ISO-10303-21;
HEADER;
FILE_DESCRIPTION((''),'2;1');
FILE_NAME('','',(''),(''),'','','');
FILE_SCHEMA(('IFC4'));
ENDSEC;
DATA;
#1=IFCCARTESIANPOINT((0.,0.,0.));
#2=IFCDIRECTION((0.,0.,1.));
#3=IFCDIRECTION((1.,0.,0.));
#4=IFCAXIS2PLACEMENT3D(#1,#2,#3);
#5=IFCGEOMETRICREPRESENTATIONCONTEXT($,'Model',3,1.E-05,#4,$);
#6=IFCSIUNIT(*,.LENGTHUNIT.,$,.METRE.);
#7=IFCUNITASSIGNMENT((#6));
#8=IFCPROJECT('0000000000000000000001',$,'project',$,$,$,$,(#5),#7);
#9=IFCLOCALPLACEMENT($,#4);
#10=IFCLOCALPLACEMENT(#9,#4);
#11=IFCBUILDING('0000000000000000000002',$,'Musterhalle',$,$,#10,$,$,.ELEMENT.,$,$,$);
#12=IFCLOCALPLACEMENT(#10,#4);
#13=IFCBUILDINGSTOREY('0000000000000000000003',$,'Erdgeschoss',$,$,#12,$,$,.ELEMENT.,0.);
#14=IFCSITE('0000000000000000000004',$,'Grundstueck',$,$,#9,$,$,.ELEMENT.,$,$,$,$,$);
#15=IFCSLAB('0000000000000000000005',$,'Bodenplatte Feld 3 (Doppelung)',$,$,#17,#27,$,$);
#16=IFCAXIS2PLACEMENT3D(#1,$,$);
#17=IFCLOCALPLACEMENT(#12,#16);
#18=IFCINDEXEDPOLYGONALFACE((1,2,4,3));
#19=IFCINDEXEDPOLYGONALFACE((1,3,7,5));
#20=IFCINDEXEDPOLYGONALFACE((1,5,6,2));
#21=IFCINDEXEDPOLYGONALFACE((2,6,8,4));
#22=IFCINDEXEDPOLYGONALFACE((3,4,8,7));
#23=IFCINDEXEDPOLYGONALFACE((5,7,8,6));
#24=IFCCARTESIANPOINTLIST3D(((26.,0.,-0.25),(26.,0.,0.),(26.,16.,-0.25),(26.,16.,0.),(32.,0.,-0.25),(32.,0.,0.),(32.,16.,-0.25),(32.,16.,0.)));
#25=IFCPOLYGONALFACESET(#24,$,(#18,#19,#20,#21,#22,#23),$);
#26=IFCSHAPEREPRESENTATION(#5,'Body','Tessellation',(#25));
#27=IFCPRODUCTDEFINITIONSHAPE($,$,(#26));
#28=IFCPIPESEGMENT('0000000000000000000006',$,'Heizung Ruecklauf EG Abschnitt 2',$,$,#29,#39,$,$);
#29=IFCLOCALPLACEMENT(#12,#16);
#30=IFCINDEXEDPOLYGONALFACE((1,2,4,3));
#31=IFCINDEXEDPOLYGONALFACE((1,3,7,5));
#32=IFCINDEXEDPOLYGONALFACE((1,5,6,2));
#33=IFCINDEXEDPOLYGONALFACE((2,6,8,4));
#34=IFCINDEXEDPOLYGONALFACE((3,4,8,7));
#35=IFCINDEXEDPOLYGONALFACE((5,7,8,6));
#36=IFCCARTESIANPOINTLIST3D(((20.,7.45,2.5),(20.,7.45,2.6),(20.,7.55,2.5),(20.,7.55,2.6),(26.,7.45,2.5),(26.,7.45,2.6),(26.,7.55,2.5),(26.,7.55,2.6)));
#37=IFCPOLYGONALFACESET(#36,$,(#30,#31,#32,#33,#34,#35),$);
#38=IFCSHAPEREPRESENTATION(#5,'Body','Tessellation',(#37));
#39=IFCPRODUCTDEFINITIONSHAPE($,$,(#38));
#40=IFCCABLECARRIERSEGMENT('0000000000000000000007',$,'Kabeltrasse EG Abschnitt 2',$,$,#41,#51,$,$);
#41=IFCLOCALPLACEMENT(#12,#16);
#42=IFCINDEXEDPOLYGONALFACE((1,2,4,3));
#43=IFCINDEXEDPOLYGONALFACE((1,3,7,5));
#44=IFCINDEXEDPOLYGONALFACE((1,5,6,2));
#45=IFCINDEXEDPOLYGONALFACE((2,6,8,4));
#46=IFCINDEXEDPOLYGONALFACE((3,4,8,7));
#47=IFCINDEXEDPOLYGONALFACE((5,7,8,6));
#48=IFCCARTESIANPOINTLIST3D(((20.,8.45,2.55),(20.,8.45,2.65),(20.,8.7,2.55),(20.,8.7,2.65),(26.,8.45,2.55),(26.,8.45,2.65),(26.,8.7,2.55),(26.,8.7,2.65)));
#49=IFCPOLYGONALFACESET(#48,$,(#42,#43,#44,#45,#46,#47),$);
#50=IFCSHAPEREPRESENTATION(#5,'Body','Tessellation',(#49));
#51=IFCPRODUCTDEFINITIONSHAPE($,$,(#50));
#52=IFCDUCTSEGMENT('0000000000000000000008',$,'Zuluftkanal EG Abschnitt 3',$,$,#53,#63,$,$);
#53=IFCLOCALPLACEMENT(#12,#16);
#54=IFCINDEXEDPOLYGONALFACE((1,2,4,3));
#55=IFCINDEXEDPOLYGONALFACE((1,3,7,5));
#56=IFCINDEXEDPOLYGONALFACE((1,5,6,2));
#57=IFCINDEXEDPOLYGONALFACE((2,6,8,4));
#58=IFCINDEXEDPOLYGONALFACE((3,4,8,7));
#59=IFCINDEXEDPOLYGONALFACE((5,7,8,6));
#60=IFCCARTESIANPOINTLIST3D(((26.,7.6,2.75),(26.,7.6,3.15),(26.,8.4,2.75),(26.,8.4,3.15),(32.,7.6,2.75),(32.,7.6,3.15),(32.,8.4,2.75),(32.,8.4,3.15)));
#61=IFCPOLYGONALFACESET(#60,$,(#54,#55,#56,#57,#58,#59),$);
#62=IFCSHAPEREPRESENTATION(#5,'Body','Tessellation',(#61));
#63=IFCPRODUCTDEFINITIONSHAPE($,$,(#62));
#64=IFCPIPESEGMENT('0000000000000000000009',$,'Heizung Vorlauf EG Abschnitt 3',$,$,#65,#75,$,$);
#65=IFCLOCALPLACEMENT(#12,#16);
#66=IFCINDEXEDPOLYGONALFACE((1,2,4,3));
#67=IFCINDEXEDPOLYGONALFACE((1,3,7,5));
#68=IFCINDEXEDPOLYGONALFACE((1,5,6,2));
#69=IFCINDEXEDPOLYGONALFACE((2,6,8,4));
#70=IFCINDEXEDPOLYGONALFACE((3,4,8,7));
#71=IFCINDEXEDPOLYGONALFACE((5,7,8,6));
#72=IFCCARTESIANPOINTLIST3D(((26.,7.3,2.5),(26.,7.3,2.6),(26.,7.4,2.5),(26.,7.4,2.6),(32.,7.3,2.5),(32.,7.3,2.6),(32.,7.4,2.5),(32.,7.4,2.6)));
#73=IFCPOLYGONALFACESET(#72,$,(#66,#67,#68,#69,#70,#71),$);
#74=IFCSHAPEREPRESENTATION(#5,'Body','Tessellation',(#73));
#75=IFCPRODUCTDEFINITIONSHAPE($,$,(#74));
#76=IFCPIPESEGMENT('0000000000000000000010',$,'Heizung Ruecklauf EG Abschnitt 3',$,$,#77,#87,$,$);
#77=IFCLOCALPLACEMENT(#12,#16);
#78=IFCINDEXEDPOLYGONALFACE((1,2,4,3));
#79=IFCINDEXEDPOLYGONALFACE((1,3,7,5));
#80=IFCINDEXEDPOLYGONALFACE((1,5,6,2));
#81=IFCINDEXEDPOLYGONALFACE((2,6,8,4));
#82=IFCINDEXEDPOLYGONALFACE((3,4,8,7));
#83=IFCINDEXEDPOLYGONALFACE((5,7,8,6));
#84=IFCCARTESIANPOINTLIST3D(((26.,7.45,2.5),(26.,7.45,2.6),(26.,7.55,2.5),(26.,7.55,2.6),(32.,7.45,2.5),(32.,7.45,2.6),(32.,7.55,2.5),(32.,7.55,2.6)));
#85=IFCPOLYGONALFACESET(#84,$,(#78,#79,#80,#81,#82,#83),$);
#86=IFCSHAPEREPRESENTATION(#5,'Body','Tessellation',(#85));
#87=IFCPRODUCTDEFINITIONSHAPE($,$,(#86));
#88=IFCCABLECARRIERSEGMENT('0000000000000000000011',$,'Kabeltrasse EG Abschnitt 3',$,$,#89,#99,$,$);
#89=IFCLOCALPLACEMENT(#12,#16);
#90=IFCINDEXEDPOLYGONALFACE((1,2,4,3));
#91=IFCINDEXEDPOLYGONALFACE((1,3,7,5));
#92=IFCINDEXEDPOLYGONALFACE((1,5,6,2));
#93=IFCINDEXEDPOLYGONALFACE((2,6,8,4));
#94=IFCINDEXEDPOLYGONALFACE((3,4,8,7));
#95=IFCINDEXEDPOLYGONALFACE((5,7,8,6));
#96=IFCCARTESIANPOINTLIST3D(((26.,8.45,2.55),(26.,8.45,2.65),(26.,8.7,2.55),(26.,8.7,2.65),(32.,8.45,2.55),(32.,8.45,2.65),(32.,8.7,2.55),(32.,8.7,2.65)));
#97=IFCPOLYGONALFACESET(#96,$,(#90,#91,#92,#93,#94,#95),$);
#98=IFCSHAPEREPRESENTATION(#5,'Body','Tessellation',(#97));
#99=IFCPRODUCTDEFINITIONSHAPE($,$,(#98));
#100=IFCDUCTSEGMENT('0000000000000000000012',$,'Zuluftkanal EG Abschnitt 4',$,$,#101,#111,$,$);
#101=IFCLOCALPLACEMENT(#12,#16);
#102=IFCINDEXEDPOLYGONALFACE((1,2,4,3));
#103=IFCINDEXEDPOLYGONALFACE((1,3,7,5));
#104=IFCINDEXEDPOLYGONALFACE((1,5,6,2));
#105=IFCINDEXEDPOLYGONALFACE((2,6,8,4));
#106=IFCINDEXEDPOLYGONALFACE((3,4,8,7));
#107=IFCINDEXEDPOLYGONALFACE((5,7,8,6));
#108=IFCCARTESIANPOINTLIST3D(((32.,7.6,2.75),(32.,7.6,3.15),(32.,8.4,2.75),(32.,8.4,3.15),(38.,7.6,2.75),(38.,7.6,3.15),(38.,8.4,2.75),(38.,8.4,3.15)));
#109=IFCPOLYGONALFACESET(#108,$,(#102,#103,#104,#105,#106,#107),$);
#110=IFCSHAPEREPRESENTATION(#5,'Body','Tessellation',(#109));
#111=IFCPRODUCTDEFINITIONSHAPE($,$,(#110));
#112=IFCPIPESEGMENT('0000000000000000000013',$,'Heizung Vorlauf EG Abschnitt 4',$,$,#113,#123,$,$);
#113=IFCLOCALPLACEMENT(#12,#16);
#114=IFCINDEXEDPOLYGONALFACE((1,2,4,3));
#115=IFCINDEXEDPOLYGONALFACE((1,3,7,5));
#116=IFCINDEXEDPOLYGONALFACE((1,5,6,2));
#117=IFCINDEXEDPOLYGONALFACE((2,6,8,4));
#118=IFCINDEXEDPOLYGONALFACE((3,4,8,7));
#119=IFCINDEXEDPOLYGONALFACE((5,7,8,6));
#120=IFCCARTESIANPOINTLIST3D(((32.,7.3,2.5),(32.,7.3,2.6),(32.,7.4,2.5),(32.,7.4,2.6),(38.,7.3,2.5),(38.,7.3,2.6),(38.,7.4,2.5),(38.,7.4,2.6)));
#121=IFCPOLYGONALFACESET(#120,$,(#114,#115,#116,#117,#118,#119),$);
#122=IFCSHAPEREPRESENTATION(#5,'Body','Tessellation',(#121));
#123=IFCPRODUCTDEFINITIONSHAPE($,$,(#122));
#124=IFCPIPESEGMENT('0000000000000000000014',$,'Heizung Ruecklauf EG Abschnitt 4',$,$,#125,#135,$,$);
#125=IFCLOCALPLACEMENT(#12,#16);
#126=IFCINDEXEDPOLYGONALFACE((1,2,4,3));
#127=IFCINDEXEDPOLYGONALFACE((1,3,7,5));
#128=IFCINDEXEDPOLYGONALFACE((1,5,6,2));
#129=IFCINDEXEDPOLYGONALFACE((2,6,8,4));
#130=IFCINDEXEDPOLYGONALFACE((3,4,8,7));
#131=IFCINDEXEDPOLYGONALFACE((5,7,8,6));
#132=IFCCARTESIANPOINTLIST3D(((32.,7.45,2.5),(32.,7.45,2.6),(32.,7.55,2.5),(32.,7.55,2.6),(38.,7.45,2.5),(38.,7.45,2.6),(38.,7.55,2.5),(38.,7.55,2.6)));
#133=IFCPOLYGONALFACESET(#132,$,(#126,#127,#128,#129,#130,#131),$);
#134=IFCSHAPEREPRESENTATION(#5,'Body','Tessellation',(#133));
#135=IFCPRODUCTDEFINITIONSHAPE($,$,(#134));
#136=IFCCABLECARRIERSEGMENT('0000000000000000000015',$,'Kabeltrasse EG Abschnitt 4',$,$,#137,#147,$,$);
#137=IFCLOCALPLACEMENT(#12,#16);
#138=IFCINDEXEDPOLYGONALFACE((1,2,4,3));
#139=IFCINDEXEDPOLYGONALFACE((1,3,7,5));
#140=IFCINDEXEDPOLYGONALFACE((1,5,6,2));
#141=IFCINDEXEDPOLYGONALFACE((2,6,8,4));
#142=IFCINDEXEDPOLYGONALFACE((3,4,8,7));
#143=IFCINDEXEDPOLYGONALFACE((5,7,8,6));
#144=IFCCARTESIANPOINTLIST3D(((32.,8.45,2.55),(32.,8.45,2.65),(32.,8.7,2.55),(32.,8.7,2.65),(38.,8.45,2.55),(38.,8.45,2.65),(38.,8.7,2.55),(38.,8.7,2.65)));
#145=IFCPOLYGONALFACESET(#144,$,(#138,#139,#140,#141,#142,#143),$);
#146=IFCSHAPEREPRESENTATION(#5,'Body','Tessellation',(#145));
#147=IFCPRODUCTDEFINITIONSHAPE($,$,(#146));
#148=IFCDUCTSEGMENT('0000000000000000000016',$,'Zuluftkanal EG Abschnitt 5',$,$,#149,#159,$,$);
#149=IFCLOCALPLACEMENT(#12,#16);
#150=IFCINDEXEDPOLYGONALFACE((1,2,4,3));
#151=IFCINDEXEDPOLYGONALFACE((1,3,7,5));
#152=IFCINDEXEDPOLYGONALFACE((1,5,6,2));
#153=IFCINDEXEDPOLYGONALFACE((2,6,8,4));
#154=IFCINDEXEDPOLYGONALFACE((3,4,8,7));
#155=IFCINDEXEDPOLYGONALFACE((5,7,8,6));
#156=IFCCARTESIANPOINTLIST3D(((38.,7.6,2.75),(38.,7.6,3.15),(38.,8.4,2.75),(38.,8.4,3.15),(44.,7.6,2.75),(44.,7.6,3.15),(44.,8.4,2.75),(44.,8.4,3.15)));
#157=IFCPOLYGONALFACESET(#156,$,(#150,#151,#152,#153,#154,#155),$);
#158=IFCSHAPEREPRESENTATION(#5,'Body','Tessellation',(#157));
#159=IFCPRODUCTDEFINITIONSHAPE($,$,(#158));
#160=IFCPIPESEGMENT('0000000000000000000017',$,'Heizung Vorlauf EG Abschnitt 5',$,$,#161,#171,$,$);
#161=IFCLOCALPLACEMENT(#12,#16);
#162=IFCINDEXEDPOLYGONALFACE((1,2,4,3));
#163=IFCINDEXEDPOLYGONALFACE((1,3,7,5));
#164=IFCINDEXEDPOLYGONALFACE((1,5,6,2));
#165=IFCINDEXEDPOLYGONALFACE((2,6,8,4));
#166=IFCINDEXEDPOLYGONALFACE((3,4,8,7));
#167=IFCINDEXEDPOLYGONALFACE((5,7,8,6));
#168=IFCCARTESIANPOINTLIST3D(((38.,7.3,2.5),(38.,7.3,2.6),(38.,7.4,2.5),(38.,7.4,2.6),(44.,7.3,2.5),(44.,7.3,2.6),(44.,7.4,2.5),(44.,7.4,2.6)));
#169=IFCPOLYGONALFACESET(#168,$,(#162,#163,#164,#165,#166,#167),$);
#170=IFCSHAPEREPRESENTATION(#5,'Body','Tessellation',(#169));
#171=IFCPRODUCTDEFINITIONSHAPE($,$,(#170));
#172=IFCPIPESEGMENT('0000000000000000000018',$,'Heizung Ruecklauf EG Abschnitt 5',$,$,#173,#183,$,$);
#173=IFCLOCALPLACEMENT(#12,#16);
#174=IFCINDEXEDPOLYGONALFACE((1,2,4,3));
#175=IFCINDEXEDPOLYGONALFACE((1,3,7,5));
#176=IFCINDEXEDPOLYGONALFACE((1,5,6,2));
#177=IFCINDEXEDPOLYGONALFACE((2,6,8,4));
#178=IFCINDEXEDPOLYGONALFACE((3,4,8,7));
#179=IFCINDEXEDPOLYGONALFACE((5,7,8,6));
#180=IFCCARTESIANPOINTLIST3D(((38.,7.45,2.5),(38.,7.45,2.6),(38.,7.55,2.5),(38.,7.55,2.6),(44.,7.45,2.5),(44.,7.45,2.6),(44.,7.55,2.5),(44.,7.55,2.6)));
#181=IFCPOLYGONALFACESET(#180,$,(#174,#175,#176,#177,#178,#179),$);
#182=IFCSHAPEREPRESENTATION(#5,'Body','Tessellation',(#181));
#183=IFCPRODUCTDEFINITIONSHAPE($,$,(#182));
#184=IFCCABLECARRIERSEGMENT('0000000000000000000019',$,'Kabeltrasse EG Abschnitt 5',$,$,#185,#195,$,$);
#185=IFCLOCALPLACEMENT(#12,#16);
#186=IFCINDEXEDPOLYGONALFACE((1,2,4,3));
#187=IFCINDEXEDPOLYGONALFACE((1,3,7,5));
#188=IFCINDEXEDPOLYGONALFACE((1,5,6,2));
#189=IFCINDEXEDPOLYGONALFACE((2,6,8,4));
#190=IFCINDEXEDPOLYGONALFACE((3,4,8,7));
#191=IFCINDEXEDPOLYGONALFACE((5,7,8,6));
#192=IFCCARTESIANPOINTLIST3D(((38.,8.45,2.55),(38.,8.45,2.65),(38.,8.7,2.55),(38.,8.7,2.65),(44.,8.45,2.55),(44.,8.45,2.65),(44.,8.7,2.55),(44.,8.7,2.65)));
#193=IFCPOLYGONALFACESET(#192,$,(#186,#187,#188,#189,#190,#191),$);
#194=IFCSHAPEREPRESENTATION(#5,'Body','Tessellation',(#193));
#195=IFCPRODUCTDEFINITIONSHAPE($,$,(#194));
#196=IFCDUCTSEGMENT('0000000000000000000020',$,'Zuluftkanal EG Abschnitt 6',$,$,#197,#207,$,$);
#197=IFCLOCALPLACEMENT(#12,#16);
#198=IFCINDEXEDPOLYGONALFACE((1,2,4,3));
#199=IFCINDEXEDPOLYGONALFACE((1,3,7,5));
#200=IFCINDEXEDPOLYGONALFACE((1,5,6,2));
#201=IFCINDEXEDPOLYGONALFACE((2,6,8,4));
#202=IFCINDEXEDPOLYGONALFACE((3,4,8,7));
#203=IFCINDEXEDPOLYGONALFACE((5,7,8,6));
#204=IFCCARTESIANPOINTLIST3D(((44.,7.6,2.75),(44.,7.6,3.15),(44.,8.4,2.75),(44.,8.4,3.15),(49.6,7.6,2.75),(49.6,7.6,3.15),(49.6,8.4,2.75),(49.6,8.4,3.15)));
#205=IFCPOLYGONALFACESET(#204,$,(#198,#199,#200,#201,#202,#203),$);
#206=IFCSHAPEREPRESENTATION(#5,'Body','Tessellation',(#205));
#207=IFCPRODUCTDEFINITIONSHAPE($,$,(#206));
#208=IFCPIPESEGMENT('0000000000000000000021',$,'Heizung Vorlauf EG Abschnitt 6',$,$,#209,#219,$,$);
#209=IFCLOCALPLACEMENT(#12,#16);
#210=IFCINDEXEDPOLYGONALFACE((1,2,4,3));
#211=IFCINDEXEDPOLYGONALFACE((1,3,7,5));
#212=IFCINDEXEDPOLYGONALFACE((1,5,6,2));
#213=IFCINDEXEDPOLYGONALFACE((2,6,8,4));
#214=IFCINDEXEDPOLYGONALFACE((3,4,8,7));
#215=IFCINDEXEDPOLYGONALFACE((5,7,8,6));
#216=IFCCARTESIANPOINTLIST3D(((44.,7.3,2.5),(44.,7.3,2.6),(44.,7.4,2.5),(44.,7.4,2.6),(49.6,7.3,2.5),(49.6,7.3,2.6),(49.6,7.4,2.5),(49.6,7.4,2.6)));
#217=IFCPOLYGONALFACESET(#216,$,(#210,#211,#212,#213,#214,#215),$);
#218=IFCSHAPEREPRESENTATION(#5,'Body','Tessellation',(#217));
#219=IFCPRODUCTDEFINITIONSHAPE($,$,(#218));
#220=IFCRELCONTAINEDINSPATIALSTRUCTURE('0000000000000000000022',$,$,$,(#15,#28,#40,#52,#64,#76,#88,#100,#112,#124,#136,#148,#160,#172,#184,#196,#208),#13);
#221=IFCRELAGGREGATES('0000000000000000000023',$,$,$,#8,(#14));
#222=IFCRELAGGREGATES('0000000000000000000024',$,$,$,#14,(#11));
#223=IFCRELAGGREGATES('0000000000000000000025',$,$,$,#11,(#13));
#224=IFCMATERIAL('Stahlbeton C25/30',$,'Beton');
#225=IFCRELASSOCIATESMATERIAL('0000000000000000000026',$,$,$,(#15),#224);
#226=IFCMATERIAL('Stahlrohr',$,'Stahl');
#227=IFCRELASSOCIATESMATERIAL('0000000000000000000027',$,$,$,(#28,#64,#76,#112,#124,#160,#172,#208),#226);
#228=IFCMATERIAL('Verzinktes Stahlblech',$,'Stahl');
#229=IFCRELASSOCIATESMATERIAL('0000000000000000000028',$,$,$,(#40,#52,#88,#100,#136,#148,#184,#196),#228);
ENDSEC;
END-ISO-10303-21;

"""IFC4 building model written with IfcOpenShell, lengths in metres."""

from ifc_helpers import new_model, si_unit, frame, origin_with_axes, origin_2d, place, context, project, spatial, rectangle, extrude, material, element, save


model = new_model("IFC4")

# Units and contexts
model_context = context("Model", 3, precision=1e-05, world=origin_with_axes())
ifc_project = project(units=[si_unit("LENGTHUNIT", "METRE")], contexts=[model_context])

# Site, building, storey
site_placement = place(None, origin_with_axes())
site = spatial("IfcSite", under=ifc_project, at=site_placement, Name="Grundstueck", CompositionType="ELEMENT")
building_placement = place(site_placement, origin_with_axes())
building = spatial("IfcBuilding", under=site, at=building_placement, Name="Musterhalle", CompositionType="ELEMENT")
storey_placement = place(building_placement, origin_with_axes())
storey = spatial("IfcBuildingStorey", under=building, at=storey_placement, Name="Erdgeschoss", CompositionType="ELEMENT", Elevation=0.0)

# Slab
ifc_material_1 = material(Name="Stahlbeton C25/30", Category="Beton")
placement = place(storey_placement, origin_with_axes())
element("IfcSlab", 1, at=placement, inside=storey, material=ifc_material_1, Name="Bodenplatte Feld 3 (Doppelung)", context=model_context, shape_type="SweptSolid", body=[
    extrude(rectangle(XDim=6.0, YDim=16.0, at=origin_2d()), frame((29.0, 8.0, -0.25), z_axis=(0.0, 0.0, 1.0), x_axis=(1.0, 0.0, 0.0)), (0.0, 0.0, 1.0), 0.25),
])

# Pipe segment
ifc_material_2 = material(Name="Stahlrohr", Category="Stahl")
element("IfcPipeSegment", 2, at=placement, inside=storey, material=ifc_material_2, Name="Heizung Ruecklauf EG Abschnitt 2", context=model_context, shape_type="SweptSolid", body=[
    extrude(rectangle(XDim=6.0, YDim=0.1, at=origin_2d()), frame((23.0, 7.5, 2.5), z_axis=(0.0, 0.0, 1.0), x_axis=(1.0, 0.0, 0.0)), (0.0, 0.0, 1.0), 0.1),
])

# Cable carrier segment
ifc_material_3 = material(Name="Verzinktes Stahlblech", Category="Stahl")
element("IfcCableCarrierSegment", 3, at=placement, inside=storey, material=ifc_material_3, Name="Kabeltrasse EG Abschnitt 2", context=model_context, shape_type="SweptSolid", body=[
    extrude(rectangle(XDim=6.0, YDim=0.25, at=origin_2d()), frame((23.0, 8.575, 2.55), z_axis=(0.0, 0.0, 1.0), x_axis=(1.0, 0.0, 0.0)), (0.0, 0.0, 1.0), 0.1),
])

# Duct segment
element("IfcDuctSegment", 4, at=placement, inside=storey, material=ifc_material_3, Name="Zuluftkanal EG Abschnitt 3", context=model_context, shape_type="SweptSolid", body=[
    extrude(rectangle(XDim=6.0, YDim=0.8, at=origin_2d()), frame((29.0, 8.0, 2.75), z_axis=(0.0, 0.0, 1.0), x_axis=(1.0, 0.0, 0.0)), (0.0, 0.0, 1.0), 0.4),
])

# Pipe segments
element("IfcPipeSegment", 5, at=placement, inside=storey, material=ifc_material_2, Name="Heizung Vorlauf EG Abschnitt 3", context=model_context, shape_type="SweptSolid", body=[
    extrude(rectangle(XDim=6.0, YDim=0.1, at=origin_2d()), frame((29.0, 7.35, 2.5), z_axis=(0.0, 0.0, 1.0), x_axis=(1.0, 0.0, 0.0)), (0.0, 0.0, 1.0), 0.1),
])
element("IfcPipeSegment", 6, at=placement, inside=storey, material=ifc_material_2, Name="Heizung Ruecklauf EG Abschnitt 3", context=model_context, shape_type="SweptSolid", body=[
    extrude(rectangle(XDim=6.0, YDim=0.1, at=origin_2d()), frame((29.0, 7.5, 2.5), z_axis=(0.0, 0.0, 1.0), x_axis=(1.0, 0.0, 0.0)), (0.0, 0.0, 1.0), 0.1),
])

# Cable carrier segment
element("IfcCableCarrierSegment", 7, at=placement, inside=storey, material=ifc_material_3, Name="Kabeltrasse EG Abschnitt 3", context=model_context, shape_type="SweptSolid", body=[
    extrude(rectangle(XDim=6.0, YDim=0.25, at=origin_2d()), frame((29.0, 8.575, 2.55), z_axis=(0.0, 0.0, 1.0), x_axis=(1.0, 0.0, 0.0)), (0.0, 0.0, 1.0), 0.1),
])

# Duct segment
element("IfcDuctSegment", 8, at=placement, inside=storey, material=ifc_material_3, Name="Zuluftkanal EG Abschnitt 4", context=model_context, shape_type="SweptSolid", body=[
    extrude(rectangle(XDim=6.0, YDim=0.8, at=origin_2d()), frame((35.0, 8.0, 2.75), z_axis=(0.0, 0.0, 1.0), x_axis=(1.0, 0.0, 0.0)), (0.0, 0.0, 1.0), 0.4),
])

# Pipe segments
element("IfcPipeSegment", 9, at=placement, inside=storey, material=ifc_material_2, Name="Heizung Vorlauf EG Abschnitt 4", context=model_context, shape_type="SweptSolid", body=[
    extrude(rectangle(XDim=6.0, YDim=0.1, at=origin_2d()), frame((35.0, 7.35, 2.5), z_axis=(0.0, 0.0, 1.0), x_axis=(1.0, 0.0, 0.0)), (0.0, 0.0, 1.0), 0.1),
])
element("IfcPipeSegment", 10, at=placement, inside=storey, material=ifc_material_2, Name="Heizung Ruecklauf EG Abschnitt 4", context=model_context, shape_type="SweptSolid", body=[
    extrude(rectangle(XDim=6.0, YDim=0.1, at=origin_2d()), frame((35.0, 7.5, 2.5), z_axis=(0.0, 0.0, 1.0), x_axis=(1.0, 0.0, 0.0)), (0.0, 0.0, 1.0), 0.1),
])

# Cable carrier segment
element("IfcCableCarrierSegment", 11, at=placement, inside=storey, material=ifc_material_3, Name="Kabeltrasse EG Abschnitt 4", context=model_context, shape_type="SweptSolid", body=[
    extrude(rectangle(XDim=6.0, YDim=0.25, at=origin_2d()), frame((35.0, 8.575, 2.55), z_axis=(0.0, 0.0, 1.0), x_axis=(1.0, 0.0, 0.0)), (0.0, 0.0, 1.0), 0.1),
])

# Duct segment
element("IfcDuctSegment", 12, at=placement, inside=storey, material=ifc_material_3, Name="Zuluftkanal EG Abschnitt 5", context=model_context, shape_type="SweptSolid", body=[
    extrude(rectangle(XDim=6.0, YDim=0.8, at=origin_2d()), frame((41.0, 8.0, 2.75), z_axis=(0.0, 0.0, 1.0), x_axis=(1.0, 0.0, 0.0)), (0.0, 0.0, 1.0), 0.4),
])

# Pipe segments
element("IfcPipeSegment", 13, at=placement, inside=storey, material=ifc_material_2, Name="Heizung Vorlauf EG Abschnitt 5", context=model_context, shape_type="SweptSolid", body=[
    extrude(rectangle(XDim=6.0, YDim=0.1, at=origin_2d()), frame((41.0, 7.35, 2.5), z_axis=(0.0, 0.0, 1.0), x_axis=(1.0, 0.0, 0.0)), (0.0, 0.0, 1.0), 0.1),
])
element("IfcPipeSegment", 14, at=placement, inside=storey, material=ifc_material_2, Name="Heizung Ruecklauf EG Abschnitt 5", context=model_context, shape_type="SweptSolid", body=[
    extrude(rectangle(XDim=6.0, YDim=0.1, at=origin_2d()), frame((41.0, 7.5, 2.5), z_axis=(0.0, 0.0, 1.0), x_axis=(1.0, 0.0, 0.0)), (0.0, 0.0, 1.0), 0.1),
])

# Cable carrier segment
element("IfcCableCarrierSegment", 15, at=placement, inside=storey, material=ifc_material_3, Name="Kabeltrasse EG Abschnitt 5", context=model_context, shape_type="SweptSolid", body=[
    extrude(rectangle(XDim=6.0, YDim=0.25, at=origin_2d()), frame((41.0, 8.575, 2.55), z_axis=(0.0, 0.0, 1.0), x_axis=(1.0, 0.0, 0.0)), (0.0, 0.0, 1.0), 0.1),
])

# Duct segment
element("IfcDuctSegment", 16, at=placement, inside=storey, material=ifc_material_3, Name="Zuluftkanal EG Abschnitt 6", context=model_context, shape_type="SweptSolid", body=[
    extrude(rectangle(XDim=5.6, YDim=0.8, at=origin_2d()), frame((46.8, 8.0, 2.75), z_axis=(0.0, 0.0, 1.0), x_axis=(1.0, 0.0, 0.0)), (0.0, 0.0, 1.0), 0.4),
])

# Pipe segment
element("IfcPipeSegment", 17, at=placement, inside=storey, material=ifc_material_2, Name="Heizung Vorlauf EG Abschnitt 6", context=model_context, shape_type="SweptSolid", body=[
    extrude(rectangle(XDim=5.6, YDim=0.1, at=origin_2d()), frame((46.8, 7.35, 2.5), z_axis=(0.0, 0.0, 1.0), x_axis=(1.0, 0.0, 0.0)), (0.0, 0.0, 1.0), 0.1),
])

save(model, "model.ifc")
